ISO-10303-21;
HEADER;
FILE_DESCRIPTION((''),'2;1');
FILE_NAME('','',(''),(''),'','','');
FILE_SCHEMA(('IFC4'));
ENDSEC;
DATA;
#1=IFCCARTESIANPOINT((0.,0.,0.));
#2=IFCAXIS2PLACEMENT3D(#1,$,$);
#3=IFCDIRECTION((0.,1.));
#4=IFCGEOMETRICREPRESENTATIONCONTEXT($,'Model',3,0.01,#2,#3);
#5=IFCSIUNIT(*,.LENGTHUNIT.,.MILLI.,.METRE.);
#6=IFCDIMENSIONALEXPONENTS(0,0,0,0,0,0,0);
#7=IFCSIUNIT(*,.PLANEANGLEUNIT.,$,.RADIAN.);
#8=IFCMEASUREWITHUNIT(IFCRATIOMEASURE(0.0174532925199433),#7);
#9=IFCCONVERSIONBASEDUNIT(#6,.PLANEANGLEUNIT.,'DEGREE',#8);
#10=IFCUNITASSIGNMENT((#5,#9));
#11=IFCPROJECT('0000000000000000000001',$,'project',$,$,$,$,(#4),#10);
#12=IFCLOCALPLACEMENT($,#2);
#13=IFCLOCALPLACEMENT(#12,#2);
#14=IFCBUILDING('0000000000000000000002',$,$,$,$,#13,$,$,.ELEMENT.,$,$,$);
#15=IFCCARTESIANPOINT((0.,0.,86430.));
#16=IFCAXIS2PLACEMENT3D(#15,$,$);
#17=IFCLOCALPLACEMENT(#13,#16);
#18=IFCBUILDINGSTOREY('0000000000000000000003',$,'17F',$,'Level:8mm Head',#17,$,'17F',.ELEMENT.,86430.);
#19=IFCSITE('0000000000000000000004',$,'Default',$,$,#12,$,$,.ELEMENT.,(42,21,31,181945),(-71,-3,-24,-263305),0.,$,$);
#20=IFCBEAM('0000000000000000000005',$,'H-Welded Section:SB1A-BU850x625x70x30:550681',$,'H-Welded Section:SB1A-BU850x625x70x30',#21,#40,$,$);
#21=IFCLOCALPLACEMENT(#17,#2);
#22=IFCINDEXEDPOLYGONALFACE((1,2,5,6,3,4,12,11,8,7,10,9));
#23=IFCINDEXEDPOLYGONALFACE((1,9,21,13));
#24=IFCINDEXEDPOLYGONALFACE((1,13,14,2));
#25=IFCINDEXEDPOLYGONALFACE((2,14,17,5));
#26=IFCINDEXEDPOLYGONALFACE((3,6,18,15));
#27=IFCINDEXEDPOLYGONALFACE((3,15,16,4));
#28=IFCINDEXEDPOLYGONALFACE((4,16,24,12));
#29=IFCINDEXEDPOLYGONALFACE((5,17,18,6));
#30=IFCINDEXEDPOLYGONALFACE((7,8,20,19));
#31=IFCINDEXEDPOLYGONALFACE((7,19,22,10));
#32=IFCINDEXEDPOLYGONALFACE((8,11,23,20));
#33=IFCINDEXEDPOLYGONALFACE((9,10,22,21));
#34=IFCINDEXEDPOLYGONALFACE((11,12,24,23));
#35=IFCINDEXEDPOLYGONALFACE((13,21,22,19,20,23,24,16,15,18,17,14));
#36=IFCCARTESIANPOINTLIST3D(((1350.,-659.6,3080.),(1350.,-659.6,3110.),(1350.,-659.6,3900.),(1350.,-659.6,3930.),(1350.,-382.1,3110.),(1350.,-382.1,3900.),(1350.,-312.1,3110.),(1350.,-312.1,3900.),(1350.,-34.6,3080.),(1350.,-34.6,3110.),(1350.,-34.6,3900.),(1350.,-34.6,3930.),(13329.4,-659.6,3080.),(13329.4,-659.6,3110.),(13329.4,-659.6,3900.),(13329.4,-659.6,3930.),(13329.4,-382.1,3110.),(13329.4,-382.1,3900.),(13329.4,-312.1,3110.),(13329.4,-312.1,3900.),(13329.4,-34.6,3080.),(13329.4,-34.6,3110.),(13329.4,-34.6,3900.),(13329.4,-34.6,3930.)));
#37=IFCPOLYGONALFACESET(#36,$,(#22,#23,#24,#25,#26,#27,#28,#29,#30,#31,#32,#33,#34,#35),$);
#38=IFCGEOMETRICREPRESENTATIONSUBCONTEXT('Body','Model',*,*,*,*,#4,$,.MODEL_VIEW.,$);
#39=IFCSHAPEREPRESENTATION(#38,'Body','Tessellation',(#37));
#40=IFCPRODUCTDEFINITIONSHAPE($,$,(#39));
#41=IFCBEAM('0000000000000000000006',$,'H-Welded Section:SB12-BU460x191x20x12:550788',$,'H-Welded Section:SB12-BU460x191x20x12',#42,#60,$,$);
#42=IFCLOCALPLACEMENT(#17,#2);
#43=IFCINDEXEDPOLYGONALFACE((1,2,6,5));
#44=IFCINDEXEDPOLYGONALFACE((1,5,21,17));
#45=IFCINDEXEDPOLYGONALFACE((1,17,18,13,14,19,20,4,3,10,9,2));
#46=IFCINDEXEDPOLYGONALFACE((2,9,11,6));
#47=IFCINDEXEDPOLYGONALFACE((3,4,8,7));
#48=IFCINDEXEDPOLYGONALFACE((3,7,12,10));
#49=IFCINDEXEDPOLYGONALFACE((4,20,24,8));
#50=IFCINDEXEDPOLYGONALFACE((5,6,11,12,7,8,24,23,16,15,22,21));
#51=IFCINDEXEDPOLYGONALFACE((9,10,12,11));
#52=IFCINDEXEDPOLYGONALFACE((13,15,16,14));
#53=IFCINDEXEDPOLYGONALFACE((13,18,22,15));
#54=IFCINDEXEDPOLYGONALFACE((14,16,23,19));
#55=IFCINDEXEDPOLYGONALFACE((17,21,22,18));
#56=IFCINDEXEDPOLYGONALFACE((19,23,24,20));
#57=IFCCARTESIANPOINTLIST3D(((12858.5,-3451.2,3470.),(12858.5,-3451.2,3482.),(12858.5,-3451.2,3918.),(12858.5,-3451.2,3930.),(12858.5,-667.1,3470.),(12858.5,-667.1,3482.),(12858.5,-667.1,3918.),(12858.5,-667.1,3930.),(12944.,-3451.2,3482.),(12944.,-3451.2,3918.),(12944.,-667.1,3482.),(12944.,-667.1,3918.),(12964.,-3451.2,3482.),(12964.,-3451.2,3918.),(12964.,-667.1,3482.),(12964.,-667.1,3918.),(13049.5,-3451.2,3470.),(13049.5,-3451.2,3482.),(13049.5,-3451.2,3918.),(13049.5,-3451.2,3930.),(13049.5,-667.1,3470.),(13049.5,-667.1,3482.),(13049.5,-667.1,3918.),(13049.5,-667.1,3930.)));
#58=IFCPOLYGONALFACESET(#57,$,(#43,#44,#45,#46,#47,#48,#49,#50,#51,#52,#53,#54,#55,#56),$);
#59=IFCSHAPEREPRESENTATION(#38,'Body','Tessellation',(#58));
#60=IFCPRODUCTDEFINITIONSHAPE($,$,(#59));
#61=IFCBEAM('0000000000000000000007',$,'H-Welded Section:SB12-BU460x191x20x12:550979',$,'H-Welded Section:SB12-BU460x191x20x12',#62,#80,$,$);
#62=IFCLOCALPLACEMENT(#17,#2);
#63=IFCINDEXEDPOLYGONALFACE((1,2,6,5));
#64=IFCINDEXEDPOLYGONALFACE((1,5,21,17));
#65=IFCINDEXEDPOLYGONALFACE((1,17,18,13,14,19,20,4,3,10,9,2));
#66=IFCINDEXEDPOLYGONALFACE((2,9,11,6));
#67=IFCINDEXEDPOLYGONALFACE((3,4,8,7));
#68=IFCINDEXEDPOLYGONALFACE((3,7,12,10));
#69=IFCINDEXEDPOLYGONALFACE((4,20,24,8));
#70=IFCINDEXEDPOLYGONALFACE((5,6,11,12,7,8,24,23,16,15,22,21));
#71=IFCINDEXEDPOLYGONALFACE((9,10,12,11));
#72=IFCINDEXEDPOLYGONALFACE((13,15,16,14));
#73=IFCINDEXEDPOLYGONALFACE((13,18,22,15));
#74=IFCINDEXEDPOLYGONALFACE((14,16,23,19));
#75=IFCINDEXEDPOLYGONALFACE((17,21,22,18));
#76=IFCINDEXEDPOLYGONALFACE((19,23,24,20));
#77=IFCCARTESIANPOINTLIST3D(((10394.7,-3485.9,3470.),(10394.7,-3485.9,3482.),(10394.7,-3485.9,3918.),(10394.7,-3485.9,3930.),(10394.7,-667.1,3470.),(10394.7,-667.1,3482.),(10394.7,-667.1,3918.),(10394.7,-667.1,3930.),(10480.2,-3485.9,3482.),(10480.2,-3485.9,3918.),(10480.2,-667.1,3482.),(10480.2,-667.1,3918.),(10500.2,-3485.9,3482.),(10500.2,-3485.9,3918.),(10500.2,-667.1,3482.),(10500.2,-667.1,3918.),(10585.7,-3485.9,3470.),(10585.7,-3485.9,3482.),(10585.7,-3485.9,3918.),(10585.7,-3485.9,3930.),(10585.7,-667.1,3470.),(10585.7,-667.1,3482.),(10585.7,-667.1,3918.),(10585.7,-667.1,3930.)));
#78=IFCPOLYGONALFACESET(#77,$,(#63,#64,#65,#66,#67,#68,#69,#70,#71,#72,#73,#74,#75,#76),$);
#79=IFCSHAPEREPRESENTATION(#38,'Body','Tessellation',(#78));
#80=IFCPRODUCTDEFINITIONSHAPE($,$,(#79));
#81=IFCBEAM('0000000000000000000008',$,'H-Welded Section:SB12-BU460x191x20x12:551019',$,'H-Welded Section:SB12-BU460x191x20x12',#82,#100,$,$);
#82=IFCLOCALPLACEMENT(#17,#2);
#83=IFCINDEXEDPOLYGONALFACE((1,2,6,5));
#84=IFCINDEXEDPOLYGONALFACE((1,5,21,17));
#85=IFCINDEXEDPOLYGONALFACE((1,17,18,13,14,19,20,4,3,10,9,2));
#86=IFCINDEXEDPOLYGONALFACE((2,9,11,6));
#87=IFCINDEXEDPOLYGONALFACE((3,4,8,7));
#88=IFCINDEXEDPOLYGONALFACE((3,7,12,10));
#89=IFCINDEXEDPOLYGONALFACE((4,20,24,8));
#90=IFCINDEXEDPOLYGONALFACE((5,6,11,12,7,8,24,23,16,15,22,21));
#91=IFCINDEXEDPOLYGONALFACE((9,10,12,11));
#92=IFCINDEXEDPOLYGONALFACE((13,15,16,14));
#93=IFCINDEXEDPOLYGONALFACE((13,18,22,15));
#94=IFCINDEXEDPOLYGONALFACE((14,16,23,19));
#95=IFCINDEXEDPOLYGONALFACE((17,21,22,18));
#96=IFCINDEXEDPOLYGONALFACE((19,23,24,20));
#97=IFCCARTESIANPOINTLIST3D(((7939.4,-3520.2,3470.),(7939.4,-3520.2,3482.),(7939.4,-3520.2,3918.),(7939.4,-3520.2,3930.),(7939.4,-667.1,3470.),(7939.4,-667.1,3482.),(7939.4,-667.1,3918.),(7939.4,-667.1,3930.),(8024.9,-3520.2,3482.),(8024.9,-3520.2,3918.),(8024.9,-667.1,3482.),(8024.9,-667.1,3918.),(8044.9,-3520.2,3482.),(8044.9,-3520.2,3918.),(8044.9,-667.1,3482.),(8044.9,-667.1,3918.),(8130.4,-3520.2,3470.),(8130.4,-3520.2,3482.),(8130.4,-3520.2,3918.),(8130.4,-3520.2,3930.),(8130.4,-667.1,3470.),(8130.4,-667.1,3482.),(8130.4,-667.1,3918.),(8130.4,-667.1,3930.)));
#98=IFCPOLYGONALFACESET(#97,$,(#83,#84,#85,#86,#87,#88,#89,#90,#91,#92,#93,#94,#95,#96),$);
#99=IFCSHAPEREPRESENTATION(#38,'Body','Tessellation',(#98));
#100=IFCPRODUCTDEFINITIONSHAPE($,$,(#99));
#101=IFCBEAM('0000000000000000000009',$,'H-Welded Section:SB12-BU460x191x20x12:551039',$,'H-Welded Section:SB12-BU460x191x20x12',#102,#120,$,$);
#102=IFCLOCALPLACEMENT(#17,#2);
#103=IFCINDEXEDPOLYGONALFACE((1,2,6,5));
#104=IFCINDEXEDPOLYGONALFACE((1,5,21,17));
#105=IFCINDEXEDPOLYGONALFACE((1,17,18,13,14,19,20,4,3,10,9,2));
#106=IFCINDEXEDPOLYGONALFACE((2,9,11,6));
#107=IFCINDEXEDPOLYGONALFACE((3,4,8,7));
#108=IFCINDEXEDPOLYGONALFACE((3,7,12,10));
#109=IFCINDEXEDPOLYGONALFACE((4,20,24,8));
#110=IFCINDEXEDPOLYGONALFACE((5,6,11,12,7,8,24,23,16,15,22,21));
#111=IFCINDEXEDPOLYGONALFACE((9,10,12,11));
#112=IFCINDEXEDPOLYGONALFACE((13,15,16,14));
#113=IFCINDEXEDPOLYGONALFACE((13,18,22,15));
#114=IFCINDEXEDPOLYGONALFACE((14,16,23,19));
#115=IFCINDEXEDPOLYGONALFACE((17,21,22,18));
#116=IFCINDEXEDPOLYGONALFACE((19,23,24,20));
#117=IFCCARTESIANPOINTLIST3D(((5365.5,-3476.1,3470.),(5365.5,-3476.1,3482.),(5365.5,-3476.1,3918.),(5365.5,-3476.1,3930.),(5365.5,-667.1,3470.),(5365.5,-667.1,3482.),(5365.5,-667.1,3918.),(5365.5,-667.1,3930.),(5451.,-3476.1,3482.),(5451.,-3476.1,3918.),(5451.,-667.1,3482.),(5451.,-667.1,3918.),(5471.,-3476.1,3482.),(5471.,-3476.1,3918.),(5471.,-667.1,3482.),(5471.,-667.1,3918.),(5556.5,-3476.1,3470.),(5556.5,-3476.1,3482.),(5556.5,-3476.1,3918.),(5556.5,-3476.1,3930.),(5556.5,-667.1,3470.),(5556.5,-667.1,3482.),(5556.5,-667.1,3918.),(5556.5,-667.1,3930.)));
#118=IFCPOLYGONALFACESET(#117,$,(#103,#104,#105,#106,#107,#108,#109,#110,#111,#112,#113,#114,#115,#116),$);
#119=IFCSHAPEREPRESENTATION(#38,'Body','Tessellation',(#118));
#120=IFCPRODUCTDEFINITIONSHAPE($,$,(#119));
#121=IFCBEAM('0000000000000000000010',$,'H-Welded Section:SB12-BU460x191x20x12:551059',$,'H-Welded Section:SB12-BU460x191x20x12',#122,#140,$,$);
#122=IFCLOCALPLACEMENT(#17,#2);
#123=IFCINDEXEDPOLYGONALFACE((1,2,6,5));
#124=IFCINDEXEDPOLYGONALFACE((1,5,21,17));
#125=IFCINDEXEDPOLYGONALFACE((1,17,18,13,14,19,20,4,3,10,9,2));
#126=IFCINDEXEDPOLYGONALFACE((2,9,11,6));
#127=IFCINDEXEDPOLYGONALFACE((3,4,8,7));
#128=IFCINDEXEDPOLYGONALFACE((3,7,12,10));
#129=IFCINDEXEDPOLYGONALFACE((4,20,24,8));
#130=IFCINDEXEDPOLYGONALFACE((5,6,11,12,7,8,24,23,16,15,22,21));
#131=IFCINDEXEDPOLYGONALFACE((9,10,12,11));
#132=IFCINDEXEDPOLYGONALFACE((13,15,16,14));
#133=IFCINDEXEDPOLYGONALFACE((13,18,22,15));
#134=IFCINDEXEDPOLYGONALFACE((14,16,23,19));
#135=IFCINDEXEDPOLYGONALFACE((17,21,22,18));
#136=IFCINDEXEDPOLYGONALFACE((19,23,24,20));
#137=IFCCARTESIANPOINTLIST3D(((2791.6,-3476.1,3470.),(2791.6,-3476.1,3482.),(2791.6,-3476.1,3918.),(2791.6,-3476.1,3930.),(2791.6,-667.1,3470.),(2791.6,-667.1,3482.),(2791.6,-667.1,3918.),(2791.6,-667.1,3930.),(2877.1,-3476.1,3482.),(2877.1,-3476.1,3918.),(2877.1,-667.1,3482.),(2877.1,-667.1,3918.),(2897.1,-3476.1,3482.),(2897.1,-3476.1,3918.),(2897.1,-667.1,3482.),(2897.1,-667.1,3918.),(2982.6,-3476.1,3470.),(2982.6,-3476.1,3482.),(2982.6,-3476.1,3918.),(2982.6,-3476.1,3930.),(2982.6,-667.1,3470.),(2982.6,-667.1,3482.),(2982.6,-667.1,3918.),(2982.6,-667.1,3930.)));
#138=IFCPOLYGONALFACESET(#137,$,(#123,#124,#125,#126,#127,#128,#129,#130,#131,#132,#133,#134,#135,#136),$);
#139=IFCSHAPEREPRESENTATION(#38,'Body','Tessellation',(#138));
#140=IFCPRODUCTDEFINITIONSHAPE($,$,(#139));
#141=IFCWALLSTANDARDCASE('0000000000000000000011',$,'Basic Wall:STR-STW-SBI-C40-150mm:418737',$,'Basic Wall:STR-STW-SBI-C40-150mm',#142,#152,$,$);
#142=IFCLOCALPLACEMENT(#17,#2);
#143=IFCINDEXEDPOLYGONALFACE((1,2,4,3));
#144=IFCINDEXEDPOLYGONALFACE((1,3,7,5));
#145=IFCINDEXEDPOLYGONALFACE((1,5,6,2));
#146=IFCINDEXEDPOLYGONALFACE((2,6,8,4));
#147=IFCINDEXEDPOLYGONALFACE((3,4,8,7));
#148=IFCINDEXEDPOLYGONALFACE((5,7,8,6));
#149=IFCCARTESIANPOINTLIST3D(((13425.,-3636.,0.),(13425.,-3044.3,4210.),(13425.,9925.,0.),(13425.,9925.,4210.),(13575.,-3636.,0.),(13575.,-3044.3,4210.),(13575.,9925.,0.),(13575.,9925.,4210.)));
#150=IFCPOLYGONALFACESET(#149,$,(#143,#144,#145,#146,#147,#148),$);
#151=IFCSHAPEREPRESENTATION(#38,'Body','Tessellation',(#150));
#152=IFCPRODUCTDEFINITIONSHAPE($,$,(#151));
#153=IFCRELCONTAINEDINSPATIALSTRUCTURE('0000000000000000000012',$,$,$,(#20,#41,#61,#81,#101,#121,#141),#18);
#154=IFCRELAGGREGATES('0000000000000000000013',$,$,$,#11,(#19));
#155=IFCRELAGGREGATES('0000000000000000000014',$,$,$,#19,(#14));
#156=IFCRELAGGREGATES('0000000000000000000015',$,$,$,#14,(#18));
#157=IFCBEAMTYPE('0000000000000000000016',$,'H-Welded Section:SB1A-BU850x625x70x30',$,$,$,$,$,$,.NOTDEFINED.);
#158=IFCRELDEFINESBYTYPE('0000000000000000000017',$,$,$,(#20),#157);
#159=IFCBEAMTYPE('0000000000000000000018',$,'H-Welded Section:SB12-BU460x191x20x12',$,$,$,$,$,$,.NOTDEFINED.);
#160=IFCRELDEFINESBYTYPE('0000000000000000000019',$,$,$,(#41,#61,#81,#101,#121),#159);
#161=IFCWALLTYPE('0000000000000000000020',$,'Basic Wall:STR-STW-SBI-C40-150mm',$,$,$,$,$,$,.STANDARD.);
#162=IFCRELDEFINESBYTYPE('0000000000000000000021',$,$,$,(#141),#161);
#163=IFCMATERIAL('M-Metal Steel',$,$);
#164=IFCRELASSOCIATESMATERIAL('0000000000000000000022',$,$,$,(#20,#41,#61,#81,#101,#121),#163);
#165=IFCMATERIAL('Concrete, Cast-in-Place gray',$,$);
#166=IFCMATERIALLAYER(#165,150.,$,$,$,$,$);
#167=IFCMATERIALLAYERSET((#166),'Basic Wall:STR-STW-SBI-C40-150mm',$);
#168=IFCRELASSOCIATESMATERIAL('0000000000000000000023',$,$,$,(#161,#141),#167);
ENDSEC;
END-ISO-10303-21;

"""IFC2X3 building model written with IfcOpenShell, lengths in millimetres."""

from ifc_helpers import new_model, entity, si_unit, converted_unit, direction, frame, frame_2d, origin, place, context, subcontext, project, spatial, rectangle, i_section, extrude, clip, halfspace, material, layer, layer_set, layer_usage, type_object, element, save


model = new_model("IFC2X3")

# Units and contexts
model_context = context("Model", 3, precision=0.01, world=origin(), true_north=direction((0.0, 1.0)))
body_context = subcontext(model_context, "Body", "Model", "MODEL_VIEW")
ifc_project = project(units=[si_unit("LENGTHUNIT", "METRE", prefix="MILLI"), converted_unit("PLANEANGLEUNIT", "DEGREE", entity("IfcRatioMeasure", 0.0174532925199433), si_unit("PLANEANGLEUNIT", "RADIAN"), dimensions=[0, 0, 0, 0, 0, 0, 0])], contexts=[model_context])

# Site, building, storey
site_placement = place(None, origin())
site = spatial("IfcSite", under=ifc_project, at=site_placement, Name="Default", CompositionType="ELEMENT", RefLatitude=(42, 21, 31, 181945), RefLongitude=(-71, -3, -24, -263305), RefElevation=0.0)
building_placement = place(site_placement, origin())
building = spatial("IfcBuilding", under=site, at=building_placement, CompositionType="ELEMENT")
storey_placement = place(building_placement, frame((0.0, 0.0, 86430.0)))
storey = spatial("IfcBuildingStorey", under=building, at=storey_placement, Name="17F", ObjectType="Level:8mm Head", LongName="17F", CompositionType="ELEMENT", Elevation=86430.0)

# Beams
ifc_material_1 = material(Name="M-Metal Steel")
beam_type_1 = type_object("IfcBeamType", Name="H-Welded Section:SB1A-BU850x625x70x30", PredefinedType="NOTDEFINED")
beam_1_placement = place(storey_placement, frame((1430.9, -347.1, 0.0)))
element("IfcBeam", 1, at=beam_1_placement, inside=storey, type_object=beam_type_1, material=ifc_material_1, Name="H-Welded Section:SB1A-BU850x625x70x30:550681", ObjectType="H-Welded Section:SB1A-BU850x625x70x30", context=body_context, shape_type="SweptSolid", body=[
    extrude(i_section(OverallWidth=625.0, OverallDepth=850.0, WebThickness=70.0, FlangeThickness=30.0, at=frame_2d((0.0, 0.0), x_axis=(0.0, 1.0))), frame((-80.9, 0.0, 3505.0), z_axis=(1.0, 0.0, 0.0), x_axis=(0.0, 0.0, -1.0)), (0.0, 0.0, 1.0), 11979.4),
])
beam_type_2 = type_object("IfcBeamType", Name="H-Welded Section:SB12-BU460x191x20x12", PredefinedType="NOTDEFINED")
beam_2_placement = place(storey_placement, frame((12954.0, -667.1, 0.0), z_axis=(0.0, 0.0, 1.0), x_axis=(0.0, -1.0, 0.0)))
element("IfcBeam", 2, at=beam_2_placement, inside=storey, type_object=beam_type_2, material=ifc_material_1, Name="H-Welded Section:SB12-BU460x191x20x12:550788", ObjectType="H-Welded Section:SB12-BU460x191x20x12", context=body_context, shape_type="SweptSolid", body=[
    extrude(i_section(OverallWidth=191.0, OverallDepth=460.0, WebThickness=20.0, FlangeThickness=12.0, at=frame_2d((0.0, 0.0), x_axis=(0.0, 1.0))), frame((0.0, 0.0, 3700.0), z_axis=(1.0, 0.0, 0.0), x_axis=(0.0, 0.0, -1.0)), (0.0, 0.0, 1.0), 2784.1),
])
beam_3_placement = place(storey_placement, frame((10490.2, -667.1, 0.0), z_axis=(0.0, 0.0, 1.0), x_axis=(0.0, -1.0, 0.0)))
element("IfcBeam", 3, at=beam_3_placement, inside=storey, type_object=beam_type_2, material=ifc_material_1, Name="H-Welded Section:SB12-BU460x191x20x12:550979", ObjectType="H-Welded Section:SB12-BU460x191x20x12", context=body_context, shape_type="SweptSolid", body=[
    extrude(i_section(OverallWidth=191.0, OverallDepth=460.0, WebThickness=20.0, FlangeThickness=12.0, at=frame_2d((0.0, 0.0), x_axis=(0.0, 1.0))), frame((0.0, 0.0, 3700.0), z_axis=(1.0, 0.0, 0.0), x_axis=(0.0, 0.0, -1.0)), (0.0, 0.0, 1.0), 2818.8),
])
beam_4_placement = place(storey_placement, frame((8034.9, -667.1, 0.0), z_axis=(0.0, 0.0, 1.0), x_axis=(0.0, -1.0, 0.0)))
element("IfcBeam", 4, at=beam_4_placement, inside=storey, type_object=beam_type_2, material=ifc_material_1, Name="H-Welded Section:SB12-BU460x191x20x12:551019", ObjectType="H-Welded Section:SB12-BU460x191x20x12", context=body_context, shape_type="SweptSolid", body=[
    extrude(i_section(OverallWidth=191.0, OverallDepth=460.0, WebThickness=20.0, FlangeThickness=12.0, at=frame_2d((0.0, 0.0), x_axis=(0.0, 1.0))), frame((0.0, 0.0, 3700.0), z_axis=(1.0, 0.0, 0.0), x_axis=(0.0, 0.0, -1.0)), (0.0, 0.0, 1.0), 2853.1),
])
beam_5_placement = place(storey_placement, frame((5461.0, -667.1, 0.0), z_axis=(0.0, 0.0, 1.0), x_axis=(0.0, -1.0, 0.0)))
element("IfcBeam", 5, at=beam_5_placement, inside=storey, type_object=beam_type_2, material=ifc_material_1, Name="H-Welded Section:SB12-BU460x191x20x12:551039", ObjectType="H-Welded Section:SB12-BU460x191x20x12", context=body_context, shape_type="SweptSolid", body=[
    extrude(i_section(OverallWidth=191.0, OverallDepth=460.0, WebThickness=20.0, FlangeThickness=12.0, at=frame_2d((0.0, 0.0), x_axis=(0.0, 1.0))), frame((0.0, 0.0, 3700.0), z_axis=(1.0, 0.0, 0.0), x_axis=(0.0, 0.0, -1.0)), (0.0, 0.0, 1.0), 2809.0),
])
beam_6_placement = place(storey_placement, frame((2887.1, -667.1, 0.0), z_axis=(0.0, 0.0, 1.0), x_axis=(0.0, -1.0, 0.0)))
element("IfcBeam", 6, at=beam_6_placement, inside=storey, type_object=beam_type_2, material=ifc_material_1, Name="H-Welded Section:SB12-BU460x191x20x12:551059", ObjectType="H-Welded Section:SB12-BU460x191x20x12", context=body_context, shape_type="SweptSolid", body=[
    extrude(i_section(OverallWidth=191.0, OverallDepth=460.0, WebThickness=20.0, FlangeThickness=12.0, at=frame_2d((0.0, 0.0), x_axis=(0.0, 1.0))), frame((0.0, 0.0, 3700.0), z_axis=(1.0, 0.0, 0.0), x_axis=(0.0, 0.0, -1.0)), (0.0, 0.0, 1.0), 2809.0),
])

# Wall
ifc_material_2 = material(Name="Concrete, Cast-in-Place gray")
ifc_layer = layer(ifc_material_2, 150.0)
ifc_layer_set = layer_set([ifc_layer], Name="Basic Wall:STR-STW-SBI-C40-150mm")
ifc_layer_usage = layer_usage(ifc_layer_set, "AXIS2", "NEGATIVE", 75.0)
wall_type = type_object("IfcWallType", Name="Basic Wall:STR-STW-SBI-C40-150mm", PredefinedType="STANDARD", material=ifc_layer_set)
wall_placement = place(storey_placement, frame((13500.0, -3636.0, 0.0), z_axis=(0.0, 0.0, 1.0), x_axis=(0.0, 1.0, 0.0)))
element("IfcWallStandardCase", 7, at=wall_placement, inside=storey, type_object=wall_type, material=ifc_layer_usage, Name="Basic Wall:STR-STW-SBI-C40-150mm:418737", ObjectType="Basic Wall:STR-STW-SBI-C40-150mm", context=body_context, shape_type="Clipping", body=[
    clip(extrude(rectangle(XDim=13561.0, YDim=150.0, at=frame_2d((6780.5, 0.0), x_axis=(-1.0, 0.0))), origin(), (0.0, 0.0, 1.0), 4210.0), halfspace(frame((0.0, -75.0, 0.0), z_axis=(-0.990268, 0.0, 0.139173), x_axis=(0.0, 1.0, 0.0)), False)),
])

save(model, "model.ifc")
